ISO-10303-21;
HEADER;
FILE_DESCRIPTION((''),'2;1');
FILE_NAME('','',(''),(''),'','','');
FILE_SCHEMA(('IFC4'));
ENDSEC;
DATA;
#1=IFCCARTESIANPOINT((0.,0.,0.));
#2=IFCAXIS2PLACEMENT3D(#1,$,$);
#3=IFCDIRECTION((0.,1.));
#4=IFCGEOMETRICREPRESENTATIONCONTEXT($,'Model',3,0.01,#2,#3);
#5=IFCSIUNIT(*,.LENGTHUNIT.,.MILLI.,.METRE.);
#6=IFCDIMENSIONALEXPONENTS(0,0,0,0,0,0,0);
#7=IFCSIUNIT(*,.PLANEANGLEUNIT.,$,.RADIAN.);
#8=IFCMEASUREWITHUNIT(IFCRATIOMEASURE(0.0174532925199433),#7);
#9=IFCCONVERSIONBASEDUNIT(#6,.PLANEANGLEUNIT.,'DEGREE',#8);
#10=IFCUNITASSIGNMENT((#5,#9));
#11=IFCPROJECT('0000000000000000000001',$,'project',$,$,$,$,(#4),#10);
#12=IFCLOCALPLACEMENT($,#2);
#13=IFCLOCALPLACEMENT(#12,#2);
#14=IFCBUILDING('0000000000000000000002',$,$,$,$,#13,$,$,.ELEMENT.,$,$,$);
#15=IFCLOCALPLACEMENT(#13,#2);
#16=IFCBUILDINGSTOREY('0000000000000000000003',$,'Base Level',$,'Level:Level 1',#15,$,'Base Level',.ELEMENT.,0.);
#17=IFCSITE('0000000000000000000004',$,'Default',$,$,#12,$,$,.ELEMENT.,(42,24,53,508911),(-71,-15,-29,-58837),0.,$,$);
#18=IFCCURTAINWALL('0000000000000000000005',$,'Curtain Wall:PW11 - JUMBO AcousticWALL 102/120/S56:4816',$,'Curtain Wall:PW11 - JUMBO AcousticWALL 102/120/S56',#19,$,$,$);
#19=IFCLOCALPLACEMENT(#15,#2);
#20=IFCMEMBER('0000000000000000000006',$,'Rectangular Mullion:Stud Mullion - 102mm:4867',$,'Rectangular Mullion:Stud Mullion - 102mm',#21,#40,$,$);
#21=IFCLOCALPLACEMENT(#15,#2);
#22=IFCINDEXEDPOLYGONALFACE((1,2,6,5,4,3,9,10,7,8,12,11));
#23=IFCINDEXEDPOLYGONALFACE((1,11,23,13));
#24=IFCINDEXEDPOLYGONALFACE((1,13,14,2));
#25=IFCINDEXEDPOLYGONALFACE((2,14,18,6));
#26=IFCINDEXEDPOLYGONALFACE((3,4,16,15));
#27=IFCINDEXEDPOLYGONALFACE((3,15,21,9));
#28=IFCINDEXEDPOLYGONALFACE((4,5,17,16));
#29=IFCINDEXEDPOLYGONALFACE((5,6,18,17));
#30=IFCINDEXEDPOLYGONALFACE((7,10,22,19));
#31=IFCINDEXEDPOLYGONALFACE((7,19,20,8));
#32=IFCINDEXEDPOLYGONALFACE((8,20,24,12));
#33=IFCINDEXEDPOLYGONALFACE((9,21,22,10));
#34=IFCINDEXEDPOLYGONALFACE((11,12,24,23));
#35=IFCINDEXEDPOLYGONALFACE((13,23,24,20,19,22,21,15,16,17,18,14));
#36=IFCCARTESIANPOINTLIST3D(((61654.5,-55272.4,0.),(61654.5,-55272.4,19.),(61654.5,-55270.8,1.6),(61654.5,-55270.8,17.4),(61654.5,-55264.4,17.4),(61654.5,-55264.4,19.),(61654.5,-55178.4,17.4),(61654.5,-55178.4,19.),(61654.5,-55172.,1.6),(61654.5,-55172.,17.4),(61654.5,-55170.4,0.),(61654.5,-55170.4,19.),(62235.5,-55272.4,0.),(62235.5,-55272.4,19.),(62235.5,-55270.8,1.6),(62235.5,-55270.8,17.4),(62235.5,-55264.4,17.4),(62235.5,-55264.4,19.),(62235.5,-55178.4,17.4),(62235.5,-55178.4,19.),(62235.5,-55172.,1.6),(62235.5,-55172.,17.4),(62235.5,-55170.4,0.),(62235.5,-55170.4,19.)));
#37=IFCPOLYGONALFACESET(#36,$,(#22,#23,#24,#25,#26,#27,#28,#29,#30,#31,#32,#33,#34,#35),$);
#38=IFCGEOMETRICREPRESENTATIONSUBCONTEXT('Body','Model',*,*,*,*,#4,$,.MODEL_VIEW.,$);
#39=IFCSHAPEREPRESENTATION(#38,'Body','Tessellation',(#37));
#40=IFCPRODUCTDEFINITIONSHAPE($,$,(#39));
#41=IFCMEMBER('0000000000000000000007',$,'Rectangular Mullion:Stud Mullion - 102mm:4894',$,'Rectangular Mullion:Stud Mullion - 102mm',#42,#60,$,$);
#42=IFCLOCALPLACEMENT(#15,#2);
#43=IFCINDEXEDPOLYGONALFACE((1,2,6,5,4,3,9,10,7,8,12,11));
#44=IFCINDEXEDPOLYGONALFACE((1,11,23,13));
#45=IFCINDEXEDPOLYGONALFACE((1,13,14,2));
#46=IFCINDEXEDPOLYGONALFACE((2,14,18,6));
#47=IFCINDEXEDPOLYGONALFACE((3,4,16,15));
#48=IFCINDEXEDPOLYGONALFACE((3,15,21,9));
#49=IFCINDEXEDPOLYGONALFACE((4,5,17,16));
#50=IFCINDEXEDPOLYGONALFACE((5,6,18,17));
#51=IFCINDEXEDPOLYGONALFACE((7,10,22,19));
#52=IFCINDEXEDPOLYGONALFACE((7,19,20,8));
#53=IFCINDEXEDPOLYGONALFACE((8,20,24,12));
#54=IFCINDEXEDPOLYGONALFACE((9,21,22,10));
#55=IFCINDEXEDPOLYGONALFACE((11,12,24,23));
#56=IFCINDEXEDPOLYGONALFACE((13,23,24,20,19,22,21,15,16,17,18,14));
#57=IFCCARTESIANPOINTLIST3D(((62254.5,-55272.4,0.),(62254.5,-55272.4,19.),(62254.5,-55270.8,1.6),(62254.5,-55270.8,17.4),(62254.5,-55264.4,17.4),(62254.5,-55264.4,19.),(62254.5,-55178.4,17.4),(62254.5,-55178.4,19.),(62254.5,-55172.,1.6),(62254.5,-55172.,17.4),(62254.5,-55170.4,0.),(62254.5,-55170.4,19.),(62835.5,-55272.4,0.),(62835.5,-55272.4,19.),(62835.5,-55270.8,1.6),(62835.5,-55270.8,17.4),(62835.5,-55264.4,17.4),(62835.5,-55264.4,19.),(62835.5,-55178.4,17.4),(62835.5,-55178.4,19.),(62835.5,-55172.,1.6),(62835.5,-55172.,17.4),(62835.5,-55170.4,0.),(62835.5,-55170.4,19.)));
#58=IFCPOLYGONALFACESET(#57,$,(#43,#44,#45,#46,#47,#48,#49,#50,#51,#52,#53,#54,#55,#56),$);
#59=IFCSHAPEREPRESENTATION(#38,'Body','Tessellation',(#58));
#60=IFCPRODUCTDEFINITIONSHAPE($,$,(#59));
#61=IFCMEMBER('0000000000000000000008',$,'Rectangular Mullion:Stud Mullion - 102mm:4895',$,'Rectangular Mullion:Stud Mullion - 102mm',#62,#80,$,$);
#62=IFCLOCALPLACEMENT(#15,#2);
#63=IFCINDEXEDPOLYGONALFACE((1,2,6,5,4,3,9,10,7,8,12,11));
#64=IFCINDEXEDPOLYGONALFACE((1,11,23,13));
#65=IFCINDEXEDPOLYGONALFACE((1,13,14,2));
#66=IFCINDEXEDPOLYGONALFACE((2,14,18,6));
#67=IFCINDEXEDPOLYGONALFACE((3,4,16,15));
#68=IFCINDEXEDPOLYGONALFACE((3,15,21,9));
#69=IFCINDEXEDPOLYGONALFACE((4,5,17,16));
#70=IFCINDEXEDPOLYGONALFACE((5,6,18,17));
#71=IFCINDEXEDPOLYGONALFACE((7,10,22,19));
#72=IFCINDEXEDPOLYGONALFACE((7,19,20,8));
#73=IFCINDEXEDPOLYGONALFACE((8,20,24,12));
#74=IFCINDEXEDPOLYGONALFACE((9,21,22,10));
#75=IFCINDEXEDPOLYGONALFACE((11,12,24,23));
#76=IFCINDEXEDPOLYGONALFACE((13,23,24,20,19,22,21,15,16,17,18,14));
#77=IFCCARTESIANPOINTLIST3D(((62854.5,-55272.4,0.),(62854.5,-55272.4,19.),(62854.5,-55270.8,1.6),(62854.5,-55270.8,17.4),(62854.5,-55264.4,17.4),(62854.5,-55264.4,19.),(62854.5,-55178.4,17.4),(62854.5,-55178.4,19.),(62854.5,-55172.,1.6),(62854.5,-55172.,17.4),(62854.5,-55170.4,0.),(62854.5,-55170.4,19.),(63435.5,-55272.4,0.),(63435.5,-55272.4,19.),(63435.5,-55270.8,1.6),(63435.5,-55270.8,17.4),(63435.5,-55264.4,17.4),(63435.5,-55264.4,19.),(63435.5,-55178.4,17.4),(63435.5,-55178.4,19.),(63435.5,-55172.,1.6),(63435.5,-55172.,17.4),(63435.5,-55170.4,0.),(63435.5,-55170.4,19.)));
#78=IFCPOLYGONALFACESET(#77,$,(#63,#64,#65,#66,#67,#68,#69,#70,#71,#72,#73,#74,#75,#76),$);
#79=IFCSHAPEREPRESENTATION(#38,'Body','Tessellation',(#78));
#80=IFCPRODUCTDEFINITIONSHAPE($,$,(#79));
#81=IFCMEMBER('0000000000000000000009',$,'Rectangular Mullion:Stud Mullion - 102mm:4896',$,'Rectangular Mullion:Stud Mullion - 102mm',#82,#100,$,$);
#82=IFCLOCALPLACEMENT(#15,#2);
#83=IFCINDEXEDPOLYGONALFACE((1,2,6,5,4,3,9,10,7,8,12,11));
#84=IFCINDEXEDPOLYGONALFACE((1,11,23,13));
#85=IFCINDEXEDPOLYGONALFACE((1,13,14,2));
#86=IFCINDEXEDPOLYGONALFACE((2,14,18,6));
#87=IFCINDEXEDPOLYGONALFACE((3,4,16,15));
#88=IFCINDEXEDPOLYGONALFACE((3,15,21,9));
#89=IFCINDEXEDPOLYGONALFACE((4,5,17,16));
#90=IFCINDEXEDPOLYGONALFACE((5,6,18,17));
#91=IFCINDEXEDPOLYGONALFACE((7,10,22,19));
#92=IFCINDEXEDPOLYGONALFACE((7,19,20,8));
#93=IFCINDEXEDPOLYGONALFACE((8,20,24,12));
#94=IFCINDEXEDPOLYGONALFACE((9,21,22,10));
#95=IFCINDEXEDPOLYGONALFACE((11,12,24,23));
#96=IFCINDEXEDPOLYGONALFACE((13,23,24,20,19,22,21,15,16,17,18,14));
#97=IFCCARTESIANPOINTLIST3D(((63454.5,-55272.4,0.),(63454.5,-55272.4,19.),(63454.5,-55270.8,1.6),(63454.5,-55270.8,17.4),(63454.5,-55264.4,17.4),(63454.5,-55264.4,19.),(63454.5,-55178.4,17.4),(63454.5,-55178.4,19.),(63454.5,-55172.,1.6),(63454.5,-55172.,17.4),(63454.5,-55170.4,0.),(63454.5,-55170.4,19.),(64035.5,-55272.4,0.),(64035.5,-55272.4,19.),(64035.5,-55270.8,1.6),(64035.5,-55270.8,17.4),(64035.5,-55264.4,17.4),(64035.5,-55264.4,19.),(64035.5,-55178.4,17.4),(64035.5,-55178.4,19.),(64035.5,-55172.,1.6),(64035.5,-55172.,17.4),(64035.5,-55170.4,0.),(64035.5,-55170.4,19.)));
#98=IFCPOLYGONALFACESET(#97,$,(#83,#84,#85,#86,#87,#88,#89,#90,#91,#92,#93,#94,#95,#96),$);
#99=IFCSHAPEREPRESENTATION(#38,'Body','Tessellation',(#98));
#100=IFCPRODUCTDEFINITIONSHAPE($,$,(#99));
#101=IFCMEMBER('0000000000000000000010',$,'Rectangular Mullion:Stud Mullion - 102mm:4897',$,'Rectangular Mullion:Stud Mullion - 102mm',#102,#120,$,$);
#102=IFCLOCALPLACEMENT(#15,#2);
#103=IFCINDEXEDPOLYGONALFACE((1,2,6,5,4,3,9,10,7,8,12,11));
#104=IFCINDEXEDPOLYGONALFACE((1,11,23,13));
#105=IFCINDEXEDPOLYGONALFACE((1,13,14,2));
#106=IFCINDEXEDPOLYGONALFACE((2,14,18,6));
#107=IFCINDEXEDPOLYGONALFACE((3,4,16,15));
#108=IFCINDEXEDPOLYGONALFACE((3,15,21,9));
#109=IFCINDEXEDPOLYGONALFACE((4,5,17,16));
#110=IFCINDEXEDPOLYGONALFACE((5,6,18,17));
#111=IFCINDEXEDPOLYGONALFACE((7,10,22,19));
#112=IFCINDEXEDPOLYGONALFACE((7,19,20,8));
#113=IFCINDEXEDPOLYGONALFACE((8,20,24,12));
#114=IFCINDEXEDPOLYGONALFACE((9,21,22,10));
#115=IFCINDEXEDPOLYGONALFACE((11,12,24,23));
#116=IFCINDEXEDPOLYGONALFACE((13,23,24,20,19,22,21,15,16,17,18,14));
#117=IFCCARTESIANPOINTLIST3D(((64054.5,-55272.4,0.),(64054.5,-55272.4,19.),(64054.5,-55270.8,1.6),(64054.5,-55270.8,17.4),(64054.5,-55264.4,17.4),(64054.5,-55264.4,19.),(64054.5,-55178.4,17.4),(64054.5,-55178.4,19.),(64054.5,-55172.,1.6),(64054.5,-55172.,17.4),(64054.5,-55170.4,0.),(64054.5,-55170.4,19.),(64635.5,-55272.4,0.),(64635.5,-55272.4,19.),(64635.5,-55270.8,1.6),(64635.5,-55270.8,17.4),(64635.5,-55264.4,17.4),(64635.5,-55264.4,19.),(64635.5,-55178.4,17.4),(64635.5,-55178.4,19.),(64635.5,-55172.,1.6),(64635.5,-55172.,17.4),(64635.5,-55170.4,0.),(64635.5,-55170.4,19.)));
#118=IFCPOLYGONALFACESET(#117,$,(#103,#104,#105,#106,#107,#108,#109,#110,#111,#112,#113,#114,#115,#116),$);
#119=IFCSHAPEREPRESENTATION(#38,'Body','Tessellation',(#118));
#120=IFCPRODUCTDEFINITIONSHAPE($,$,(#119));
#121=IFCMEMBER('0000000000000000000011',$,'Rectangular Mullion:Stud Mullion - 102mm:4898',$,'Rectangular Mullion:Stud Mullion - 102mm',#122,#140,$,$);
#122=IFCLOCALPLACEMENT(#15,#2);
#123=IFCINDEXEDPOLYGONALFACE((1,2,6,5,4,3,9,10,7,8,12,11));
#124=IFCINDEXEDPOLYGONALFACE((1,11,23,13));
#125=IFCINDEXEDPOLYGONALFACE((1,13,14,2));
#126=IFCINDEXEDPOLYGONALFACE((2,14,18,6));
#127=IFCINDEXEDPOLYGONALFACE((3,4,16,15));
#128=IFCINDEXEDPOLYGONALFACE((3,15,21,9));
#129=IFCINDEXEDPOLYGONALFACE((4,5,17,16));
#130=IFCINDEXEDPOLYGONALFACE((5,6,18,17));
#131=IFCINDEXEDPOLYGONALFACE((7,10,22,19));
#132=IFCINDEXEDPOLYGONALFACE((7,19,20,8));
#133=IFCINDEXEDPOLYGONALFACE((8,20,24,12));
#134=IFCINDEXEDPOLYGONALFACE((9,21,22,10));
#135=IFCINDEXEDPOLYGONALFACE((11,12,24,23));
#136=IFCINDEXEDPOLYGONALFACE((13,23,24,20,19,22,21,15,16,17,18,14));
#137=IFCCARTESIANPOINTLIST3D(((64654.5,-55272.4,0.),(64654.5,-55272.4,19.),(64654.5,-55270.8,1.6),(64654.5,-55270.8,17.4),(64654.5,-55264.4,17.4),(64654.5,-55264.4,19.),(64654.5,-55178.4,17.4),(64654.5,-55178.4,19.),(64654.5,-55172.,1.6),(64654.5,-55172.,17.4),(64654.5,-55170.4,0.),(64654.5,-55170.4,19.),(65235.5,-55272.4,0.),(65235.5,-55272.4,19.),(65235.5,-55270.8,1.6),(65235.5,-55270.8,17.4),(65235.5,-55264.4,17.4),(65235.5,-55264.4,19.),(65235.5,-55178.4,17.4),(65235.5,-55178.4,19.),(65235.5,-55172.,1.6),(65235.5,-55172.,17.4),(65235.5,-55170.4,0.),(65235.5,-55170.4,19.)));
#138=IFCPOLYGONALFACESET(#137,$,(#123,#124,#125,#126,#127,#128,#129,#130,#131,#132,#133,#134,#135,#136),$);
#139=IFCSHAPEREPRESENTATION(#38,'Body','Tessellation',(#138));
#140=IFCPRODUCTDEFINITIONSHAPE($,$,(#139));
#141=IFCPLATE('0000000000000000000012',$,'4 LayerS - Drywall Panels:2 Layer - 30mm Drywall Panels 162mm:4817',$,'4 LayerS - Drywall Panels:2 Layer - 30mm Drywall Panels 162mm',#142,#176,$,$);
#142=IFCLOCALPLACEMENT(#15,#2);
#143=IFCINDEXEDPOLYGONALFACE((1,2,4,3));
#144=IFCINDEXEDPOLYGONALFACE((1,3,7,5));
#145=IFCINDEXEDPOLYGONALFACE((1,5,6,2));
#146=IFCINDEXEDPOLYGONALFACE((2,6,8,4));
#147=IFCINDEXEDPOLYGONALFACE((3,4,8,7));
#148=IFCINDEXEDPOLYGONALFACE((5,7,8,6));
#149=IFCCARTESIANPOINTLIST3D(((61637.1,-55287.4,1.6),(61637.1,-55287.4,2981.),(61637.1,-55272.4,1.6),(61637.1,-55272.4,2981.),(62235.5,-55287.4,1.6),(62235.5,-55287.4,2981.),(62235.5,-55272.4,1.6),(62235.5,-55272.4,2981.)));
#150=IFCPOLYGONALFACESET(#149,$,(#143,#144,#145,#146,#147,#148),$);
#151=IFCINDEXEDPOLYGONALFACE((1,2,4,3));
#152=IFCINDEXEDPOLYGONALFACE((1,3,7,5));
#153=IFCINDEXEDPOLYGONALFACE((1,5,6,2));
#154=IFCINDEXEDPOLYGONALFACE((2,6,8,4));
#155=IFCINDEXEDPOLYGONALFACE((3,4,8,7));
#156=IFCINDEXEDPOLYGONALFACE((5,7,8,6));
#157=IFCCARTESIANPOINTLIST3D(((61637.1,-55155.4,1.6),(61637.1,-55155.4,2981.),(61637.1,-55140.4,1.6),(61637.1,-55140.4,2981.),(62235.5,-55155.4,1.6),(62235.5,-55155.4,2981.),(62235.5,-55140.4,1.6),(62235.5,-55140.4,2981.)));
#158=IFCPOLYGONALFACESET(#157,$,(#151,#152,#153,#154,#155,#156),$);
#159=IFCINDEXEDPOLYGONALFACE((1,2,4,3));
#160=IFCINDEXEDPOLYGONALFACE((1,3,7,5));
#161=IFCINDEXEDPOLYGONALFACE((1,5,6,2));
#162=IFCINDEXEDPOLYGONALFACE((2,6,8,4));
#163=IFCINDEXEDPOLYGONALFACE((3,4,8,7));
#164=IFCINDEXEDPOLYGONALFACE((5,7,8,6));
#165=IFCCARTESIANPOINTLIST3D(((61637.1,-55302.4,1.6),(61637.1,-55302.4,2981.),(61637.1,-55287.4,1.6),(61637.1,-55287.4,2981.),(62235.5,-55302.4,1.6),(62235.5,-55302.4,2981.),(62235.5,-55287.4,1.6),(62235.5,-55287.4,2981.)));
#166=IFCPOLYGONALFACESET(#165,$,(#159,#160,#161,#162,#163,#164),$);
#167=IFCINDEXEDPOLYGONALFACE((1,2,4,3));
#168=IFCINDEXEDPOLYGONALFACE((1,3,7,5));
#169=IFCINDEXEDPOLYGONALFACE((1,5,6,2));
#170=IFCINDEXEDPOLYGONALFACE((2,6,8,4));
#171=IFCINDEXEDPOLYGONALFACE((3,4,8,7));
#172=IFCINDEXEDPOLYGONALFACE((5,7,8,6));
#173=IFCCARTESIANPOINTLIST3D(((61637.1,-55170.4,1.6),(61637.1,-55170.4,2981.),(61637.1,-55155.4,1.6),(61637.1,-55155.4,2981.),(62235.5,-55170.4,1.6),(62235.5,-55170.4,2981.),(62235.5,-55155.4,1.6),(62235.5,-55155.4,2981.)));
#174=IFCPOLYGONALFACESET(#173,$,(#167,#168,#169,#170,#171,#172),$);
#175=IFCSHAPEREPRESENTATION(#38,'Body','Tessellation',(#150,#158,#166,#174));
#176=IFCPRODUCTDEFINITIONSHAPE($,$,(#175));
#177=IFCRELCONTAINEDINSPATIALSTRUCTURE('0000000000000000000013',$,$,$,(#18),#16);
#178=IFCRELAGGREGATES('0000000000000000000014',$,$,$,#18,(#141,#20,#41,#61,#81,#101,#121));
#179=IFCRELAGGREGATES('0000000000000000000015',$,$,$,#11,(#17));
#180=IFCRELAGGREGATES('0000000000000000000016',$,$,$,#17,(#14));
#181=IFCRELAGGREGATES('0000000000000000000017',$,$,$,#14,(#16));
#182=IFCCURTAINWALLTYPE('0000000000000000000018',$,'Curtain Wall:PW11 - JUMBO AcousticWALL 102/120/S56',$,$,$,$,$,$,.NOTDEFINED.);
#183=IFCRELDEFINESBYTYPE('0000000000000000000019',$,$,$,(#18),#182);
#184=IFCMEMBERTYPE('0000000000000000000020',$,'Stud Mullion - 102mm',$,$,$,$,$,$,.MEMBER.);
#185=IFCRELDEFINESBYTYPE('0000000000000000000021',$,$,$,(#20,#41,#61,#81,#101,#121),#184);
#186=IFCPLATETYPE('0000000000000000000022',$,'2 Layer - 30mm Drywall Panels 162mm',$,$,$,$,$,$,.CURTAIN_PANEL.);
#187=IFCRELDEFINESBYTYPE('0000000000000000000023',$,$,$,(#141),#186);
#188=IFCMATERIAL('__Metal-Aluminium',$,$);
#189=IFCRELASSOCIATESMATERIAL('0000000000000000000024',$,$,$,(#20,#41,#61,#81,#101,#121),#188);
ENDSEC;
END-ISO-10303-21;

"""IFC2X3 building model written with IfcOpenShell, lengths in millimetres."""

from ifc_helpers import new_model, entity, si_unit, converted_unit, direction, frame, frame_2d, origin, origin_2d_with_axis, place, context, subcontext, project, spatial, polyline, rectangle, outline, extrude, source, transform, mapped, material, type_object, type_shapes, element, aggregate, save


model = new_model("IFC2X3")

# Units and contexts
model_context = context("Model", 3, precision=0.01, world=origin(), true_north=direction((0.0, 1.0)))
body_context = subcontext(model_context, "Body", "Model", "MODEL_VIEW")
ifc_project = project(units=[si_unit("LENGTHUNIT", "METRE", prefix="MILLI"), converted_unit("PLANEANGLEUNIT", "DEGREE", entity("IfcRatioMeasure", 0.0174532925199433), si_unit("PLANEANGLEUNIT", "RADIAN"), dimensions=[0, 0, 0, 0, 0, 0, 0])], contexts=[model_context])

# Site, building, storey
site_placement = place(None, origin())
site = spatial("IfcSite", under=ifc_project, at=site_placement, Name="Default", CompositionType="ELEMENT", RefLatitude=(42, 24, 53, 508911), RefLongitude=(-71, -15, -29, -58837), RefElevation=0.0)
building_placement = place(site_placement, origin())
building = spatial("IfcBuilding", under=site, at=building_placement, CompositionType="ELEMENT")
storey_placement = place(building_placement, origin())
storey = spatial("IfcBuildingStorey", under=building, at=storey_placement, Name="Base Level", ObjectType="Level:Level 1", LongName="Base Level", CompositionType="ELEMENT", Elevation=0.0)

# Curtain wall, members, plate
curtain_wall_type = type_object("IfcCurtainWallType", Name="Curtain Wall:PW11 - JUMBO AcousticWALL 102/120/S56", PredefinedType="NOTDEFINED")
curtain_wall_placement = place(building_placement, origin())
curtain_wall = element("IfcCurtainWall", 1, at=curtain_wall_placement, inside=storey, type_object=curtain_wall_type, Name="Curtain Wall:PW11 - JUMBO AcousticWALL 102/120/S56:4816", ObjectType="Curtain Wall:PW11 - JUMBO AcousticWALL 102/120/S56")
ifc_material_1 = material(Name="__Metal-Aluminium")
member_type_1 = type_object("IfcMemberType", Name="Stud Mullion - 102mm", PredefinedType="MEMBER")
shared_shape_1 = source(origin(), body_context, "Body", "SweptSolid", [
    extrude(outline(polyline([(43.0, -6.6), (51.0, -6.6), (51.0, 12.4), (-51.0, 12.4), (-51.0, -6.6), (-43.0, -6.6), (-43.0, -5.0), (-49.4, -5.0), (-49.4, 10.8), (49.4, 10.8), (49.4, -5.0), (43.0, -5.0), (43.0, -6.6)])), frame((-12.4, 0.0, -581.0), z_axis=(0.0, 0.0, 1.0), x_axis=(0.0, -1.0, 0.0)), (0.0, 0.0, 1.0), 581.0),
])
type_shapes(member_type_1, [shared_shape_1])
member_1_placement = place(building_placement, frame((61654.5, -55221.4, 0.0), z_axis=(-1.0, 0.0, 0.0), x_axis=(0.0, 0.0, -1.0)))
member_1 = element("IfcMember", 2, at=member_1_placement, type_object=member_type_1, material=ifc_material_1, Name="Rectangular Mullion:Stud Mullion - 102mm:4867", ObjectType="Rectangular Mullion:Stud Mullion - 102mm", context=body_context, shape_type="MappedRepresentation", body=[
    mapped(shared_shape_1, transform((0.0, 0.0, 0.0), scale=1.0)),
])
member_2_placement = place(building_placement, frame((62254.5, -55221.4, 0.0), z_axis=(-1.0, 0.0, 0.0), x_axis=(0.0, 0.0, -1.0)))
member_2 = element("IfcMember", 3, at=member_2_placement, type_object=member_type_1, material=ifc_material_1, Name="Rectangular Mullion:Stud Mullion - 102mm:4894", ObjectType="Rectangular Mullion:Stud Mullion - 102mm", context=body_context, shape_type="MappedRepresentation", body=[
    mapped(shared_shape_1, transform((0.0, 0.0, 0.0), scale=1.0)),
])
member_3_placement = place(building_placement, frame((62854.5, -55221.4, 0.0), z_axis=(-1.0, 0.0, 0.0), x_axis=(0.0, 0.0, -1.0)))
member_3 = element("IfcMember", 4, at=member_3_placement, type_object=member_type_1, material=ifc_material_1, Name="Rectangular Mullion:Stud Mullion - 102mm:4895", ObjectType="Rectangular Mullion:Stud Mullion - 102mm", context=body_context, shape_type="MappedRepresentation", body=[
    mapped(shared_shape_1, transform((0.0, 0.0, 0.0), scale=1.0)),
])
member_4_placement = place(building_placement, frame((63454.5, -55221.4, 0.0), z_axis=(-1.0, 0.0, 0.0), x_axis=(0.0, 0.0, -1.0)))
member_4 = element("IfcMember", 5, at=member_4_placement, type_object=member_type_1, material=ifc_material_1, Name="Rectangular Mullion:Stud Mullion - 102mm:4896", ObjectType="Rectangular Mullion:Stud Mullion - 102mm", context=body_context, shape_type="MappedRepresentation", body=[
    mapped(shared_shape_1, transform((0.0, 0.0, 0.0), scale=1.0)),
])
member_5_placement = place(building_placement, frame((64054.5, -55221.4, 0.0), z_axis=(-1.0, 0.0, 0.0), x_axis=(0.0, 0.0, -1.0)))
member_5 = element("IfcMember", 6, at=member_5_placement, type_object=member_type_1, material=ifc_material_1, Name="Rectangular Mullion:Stud Mullion - 102mm:4897", ObjectType="Rectangular Mullion:Stud Mullion - 102mm", context=body_context, shape_type="MappedRepresentation", body=[
    mapped(shared_shape_1, transform((0.0, 0.0, 0.0), scale=1.0)),
])
member_6_placement = place(building_placement, frame((64654.5, -55221.4, 0.0), z_axis=(-1.0, 0.0, 0.0), x_axis=(0.0, 0.0, -1.0)))
member_6 = element("IfcMember", 7, at=member_6_placement, type_object=member_type_1, material=ifc_material_1, Name="Rectangular Mullion:Stud Mullion - 102mm:4898", ObjectType="Rectangular Mullion:Stud Mullion - 102mm", context=body_context, shape_type="MappedRepresentation", body=[
    mapped(shared_shape_1, transform((0.0, 0.0, 0.0), scale=1.0)),
])
plate_type = type_object("IfcPlateType", Name="2 Layer - 30mm Drywall Panels 162mm", PredefinedType="CURTAIN_PANEL")
shared_shape_2 = source(origin(), body_context, "Body", "SweptSolid", [
    extrude(rectangle(XDim=15.0, YDim=598.4, at=origin_2d_with_axis()), frame((0.0, -58.5, 0.0), z_axis=(0.0, 0.0, 1.0), x_axis=(0.0, 1.0, 0.0)), (0.0, 0.0, 1.0), 2979.4),
    extrude(rectangle(XDim=15.0, YDim=598.4, at=frame_2d((0.0, 0.0), x_axis=(1.0, 0.0))), frame((0.0, 73.5, 0.0), z_axis=(0.0, 0.0, 1.0), x_axis=(0.0, 1.0, 0.0)), (0.0, 0.0, 1.0), 2979.4),
    extrude(rectangle(XDim=598.4, YDim=15.0, at=origin_2d_with_axis()), frame((0.0, -73.5, 0.0), z_axis=(0.0, 0.0, 1.0), x_axis=(-1.0, 0.0, 0.0)), (0.0, 0.0, 1.0), 2979.4),
    extrude(rectangle(XDim=15.0, YDim=598.4, at=frame_2d((0.0, 0.0), x_axis=(1.0, 0.0))), frame((0.0, 58.5, 0.0), z_axis=(0.0, 0.0, 1.0), x_axis=(0.0, 1.0, 0.0)), (0.0, 0.0, 1.0), 2979.4),
])
type_shapes(plate_type, [shared_shape_2])
plate_1_placement = place(curtain_wall_placement, frame((61936.3, -55221.4, 1.6)))
plate_1 = element("IfcPlate", 8, at=plate_1_placement, type_object=plate_type, Name="4 LayerS - Drywall Panels:2 Layer - 30mm Drywall Panels 162mm:4817", ObjectType="4 LayerS - Drywall Panels:2 Layer - 30mm Drywall Panels 162mm", context=body_context, shape_type="MappedRepresentation", body=[
    mapped(shared_shape_2, transform((0.0, 0.0, 0.0), scale=1.0)),
])
aggregate(curtain_wall, [plate_1, member_1, member_2, member_3, member_4, member_5, member_6])

save(model, "model.ifc")
